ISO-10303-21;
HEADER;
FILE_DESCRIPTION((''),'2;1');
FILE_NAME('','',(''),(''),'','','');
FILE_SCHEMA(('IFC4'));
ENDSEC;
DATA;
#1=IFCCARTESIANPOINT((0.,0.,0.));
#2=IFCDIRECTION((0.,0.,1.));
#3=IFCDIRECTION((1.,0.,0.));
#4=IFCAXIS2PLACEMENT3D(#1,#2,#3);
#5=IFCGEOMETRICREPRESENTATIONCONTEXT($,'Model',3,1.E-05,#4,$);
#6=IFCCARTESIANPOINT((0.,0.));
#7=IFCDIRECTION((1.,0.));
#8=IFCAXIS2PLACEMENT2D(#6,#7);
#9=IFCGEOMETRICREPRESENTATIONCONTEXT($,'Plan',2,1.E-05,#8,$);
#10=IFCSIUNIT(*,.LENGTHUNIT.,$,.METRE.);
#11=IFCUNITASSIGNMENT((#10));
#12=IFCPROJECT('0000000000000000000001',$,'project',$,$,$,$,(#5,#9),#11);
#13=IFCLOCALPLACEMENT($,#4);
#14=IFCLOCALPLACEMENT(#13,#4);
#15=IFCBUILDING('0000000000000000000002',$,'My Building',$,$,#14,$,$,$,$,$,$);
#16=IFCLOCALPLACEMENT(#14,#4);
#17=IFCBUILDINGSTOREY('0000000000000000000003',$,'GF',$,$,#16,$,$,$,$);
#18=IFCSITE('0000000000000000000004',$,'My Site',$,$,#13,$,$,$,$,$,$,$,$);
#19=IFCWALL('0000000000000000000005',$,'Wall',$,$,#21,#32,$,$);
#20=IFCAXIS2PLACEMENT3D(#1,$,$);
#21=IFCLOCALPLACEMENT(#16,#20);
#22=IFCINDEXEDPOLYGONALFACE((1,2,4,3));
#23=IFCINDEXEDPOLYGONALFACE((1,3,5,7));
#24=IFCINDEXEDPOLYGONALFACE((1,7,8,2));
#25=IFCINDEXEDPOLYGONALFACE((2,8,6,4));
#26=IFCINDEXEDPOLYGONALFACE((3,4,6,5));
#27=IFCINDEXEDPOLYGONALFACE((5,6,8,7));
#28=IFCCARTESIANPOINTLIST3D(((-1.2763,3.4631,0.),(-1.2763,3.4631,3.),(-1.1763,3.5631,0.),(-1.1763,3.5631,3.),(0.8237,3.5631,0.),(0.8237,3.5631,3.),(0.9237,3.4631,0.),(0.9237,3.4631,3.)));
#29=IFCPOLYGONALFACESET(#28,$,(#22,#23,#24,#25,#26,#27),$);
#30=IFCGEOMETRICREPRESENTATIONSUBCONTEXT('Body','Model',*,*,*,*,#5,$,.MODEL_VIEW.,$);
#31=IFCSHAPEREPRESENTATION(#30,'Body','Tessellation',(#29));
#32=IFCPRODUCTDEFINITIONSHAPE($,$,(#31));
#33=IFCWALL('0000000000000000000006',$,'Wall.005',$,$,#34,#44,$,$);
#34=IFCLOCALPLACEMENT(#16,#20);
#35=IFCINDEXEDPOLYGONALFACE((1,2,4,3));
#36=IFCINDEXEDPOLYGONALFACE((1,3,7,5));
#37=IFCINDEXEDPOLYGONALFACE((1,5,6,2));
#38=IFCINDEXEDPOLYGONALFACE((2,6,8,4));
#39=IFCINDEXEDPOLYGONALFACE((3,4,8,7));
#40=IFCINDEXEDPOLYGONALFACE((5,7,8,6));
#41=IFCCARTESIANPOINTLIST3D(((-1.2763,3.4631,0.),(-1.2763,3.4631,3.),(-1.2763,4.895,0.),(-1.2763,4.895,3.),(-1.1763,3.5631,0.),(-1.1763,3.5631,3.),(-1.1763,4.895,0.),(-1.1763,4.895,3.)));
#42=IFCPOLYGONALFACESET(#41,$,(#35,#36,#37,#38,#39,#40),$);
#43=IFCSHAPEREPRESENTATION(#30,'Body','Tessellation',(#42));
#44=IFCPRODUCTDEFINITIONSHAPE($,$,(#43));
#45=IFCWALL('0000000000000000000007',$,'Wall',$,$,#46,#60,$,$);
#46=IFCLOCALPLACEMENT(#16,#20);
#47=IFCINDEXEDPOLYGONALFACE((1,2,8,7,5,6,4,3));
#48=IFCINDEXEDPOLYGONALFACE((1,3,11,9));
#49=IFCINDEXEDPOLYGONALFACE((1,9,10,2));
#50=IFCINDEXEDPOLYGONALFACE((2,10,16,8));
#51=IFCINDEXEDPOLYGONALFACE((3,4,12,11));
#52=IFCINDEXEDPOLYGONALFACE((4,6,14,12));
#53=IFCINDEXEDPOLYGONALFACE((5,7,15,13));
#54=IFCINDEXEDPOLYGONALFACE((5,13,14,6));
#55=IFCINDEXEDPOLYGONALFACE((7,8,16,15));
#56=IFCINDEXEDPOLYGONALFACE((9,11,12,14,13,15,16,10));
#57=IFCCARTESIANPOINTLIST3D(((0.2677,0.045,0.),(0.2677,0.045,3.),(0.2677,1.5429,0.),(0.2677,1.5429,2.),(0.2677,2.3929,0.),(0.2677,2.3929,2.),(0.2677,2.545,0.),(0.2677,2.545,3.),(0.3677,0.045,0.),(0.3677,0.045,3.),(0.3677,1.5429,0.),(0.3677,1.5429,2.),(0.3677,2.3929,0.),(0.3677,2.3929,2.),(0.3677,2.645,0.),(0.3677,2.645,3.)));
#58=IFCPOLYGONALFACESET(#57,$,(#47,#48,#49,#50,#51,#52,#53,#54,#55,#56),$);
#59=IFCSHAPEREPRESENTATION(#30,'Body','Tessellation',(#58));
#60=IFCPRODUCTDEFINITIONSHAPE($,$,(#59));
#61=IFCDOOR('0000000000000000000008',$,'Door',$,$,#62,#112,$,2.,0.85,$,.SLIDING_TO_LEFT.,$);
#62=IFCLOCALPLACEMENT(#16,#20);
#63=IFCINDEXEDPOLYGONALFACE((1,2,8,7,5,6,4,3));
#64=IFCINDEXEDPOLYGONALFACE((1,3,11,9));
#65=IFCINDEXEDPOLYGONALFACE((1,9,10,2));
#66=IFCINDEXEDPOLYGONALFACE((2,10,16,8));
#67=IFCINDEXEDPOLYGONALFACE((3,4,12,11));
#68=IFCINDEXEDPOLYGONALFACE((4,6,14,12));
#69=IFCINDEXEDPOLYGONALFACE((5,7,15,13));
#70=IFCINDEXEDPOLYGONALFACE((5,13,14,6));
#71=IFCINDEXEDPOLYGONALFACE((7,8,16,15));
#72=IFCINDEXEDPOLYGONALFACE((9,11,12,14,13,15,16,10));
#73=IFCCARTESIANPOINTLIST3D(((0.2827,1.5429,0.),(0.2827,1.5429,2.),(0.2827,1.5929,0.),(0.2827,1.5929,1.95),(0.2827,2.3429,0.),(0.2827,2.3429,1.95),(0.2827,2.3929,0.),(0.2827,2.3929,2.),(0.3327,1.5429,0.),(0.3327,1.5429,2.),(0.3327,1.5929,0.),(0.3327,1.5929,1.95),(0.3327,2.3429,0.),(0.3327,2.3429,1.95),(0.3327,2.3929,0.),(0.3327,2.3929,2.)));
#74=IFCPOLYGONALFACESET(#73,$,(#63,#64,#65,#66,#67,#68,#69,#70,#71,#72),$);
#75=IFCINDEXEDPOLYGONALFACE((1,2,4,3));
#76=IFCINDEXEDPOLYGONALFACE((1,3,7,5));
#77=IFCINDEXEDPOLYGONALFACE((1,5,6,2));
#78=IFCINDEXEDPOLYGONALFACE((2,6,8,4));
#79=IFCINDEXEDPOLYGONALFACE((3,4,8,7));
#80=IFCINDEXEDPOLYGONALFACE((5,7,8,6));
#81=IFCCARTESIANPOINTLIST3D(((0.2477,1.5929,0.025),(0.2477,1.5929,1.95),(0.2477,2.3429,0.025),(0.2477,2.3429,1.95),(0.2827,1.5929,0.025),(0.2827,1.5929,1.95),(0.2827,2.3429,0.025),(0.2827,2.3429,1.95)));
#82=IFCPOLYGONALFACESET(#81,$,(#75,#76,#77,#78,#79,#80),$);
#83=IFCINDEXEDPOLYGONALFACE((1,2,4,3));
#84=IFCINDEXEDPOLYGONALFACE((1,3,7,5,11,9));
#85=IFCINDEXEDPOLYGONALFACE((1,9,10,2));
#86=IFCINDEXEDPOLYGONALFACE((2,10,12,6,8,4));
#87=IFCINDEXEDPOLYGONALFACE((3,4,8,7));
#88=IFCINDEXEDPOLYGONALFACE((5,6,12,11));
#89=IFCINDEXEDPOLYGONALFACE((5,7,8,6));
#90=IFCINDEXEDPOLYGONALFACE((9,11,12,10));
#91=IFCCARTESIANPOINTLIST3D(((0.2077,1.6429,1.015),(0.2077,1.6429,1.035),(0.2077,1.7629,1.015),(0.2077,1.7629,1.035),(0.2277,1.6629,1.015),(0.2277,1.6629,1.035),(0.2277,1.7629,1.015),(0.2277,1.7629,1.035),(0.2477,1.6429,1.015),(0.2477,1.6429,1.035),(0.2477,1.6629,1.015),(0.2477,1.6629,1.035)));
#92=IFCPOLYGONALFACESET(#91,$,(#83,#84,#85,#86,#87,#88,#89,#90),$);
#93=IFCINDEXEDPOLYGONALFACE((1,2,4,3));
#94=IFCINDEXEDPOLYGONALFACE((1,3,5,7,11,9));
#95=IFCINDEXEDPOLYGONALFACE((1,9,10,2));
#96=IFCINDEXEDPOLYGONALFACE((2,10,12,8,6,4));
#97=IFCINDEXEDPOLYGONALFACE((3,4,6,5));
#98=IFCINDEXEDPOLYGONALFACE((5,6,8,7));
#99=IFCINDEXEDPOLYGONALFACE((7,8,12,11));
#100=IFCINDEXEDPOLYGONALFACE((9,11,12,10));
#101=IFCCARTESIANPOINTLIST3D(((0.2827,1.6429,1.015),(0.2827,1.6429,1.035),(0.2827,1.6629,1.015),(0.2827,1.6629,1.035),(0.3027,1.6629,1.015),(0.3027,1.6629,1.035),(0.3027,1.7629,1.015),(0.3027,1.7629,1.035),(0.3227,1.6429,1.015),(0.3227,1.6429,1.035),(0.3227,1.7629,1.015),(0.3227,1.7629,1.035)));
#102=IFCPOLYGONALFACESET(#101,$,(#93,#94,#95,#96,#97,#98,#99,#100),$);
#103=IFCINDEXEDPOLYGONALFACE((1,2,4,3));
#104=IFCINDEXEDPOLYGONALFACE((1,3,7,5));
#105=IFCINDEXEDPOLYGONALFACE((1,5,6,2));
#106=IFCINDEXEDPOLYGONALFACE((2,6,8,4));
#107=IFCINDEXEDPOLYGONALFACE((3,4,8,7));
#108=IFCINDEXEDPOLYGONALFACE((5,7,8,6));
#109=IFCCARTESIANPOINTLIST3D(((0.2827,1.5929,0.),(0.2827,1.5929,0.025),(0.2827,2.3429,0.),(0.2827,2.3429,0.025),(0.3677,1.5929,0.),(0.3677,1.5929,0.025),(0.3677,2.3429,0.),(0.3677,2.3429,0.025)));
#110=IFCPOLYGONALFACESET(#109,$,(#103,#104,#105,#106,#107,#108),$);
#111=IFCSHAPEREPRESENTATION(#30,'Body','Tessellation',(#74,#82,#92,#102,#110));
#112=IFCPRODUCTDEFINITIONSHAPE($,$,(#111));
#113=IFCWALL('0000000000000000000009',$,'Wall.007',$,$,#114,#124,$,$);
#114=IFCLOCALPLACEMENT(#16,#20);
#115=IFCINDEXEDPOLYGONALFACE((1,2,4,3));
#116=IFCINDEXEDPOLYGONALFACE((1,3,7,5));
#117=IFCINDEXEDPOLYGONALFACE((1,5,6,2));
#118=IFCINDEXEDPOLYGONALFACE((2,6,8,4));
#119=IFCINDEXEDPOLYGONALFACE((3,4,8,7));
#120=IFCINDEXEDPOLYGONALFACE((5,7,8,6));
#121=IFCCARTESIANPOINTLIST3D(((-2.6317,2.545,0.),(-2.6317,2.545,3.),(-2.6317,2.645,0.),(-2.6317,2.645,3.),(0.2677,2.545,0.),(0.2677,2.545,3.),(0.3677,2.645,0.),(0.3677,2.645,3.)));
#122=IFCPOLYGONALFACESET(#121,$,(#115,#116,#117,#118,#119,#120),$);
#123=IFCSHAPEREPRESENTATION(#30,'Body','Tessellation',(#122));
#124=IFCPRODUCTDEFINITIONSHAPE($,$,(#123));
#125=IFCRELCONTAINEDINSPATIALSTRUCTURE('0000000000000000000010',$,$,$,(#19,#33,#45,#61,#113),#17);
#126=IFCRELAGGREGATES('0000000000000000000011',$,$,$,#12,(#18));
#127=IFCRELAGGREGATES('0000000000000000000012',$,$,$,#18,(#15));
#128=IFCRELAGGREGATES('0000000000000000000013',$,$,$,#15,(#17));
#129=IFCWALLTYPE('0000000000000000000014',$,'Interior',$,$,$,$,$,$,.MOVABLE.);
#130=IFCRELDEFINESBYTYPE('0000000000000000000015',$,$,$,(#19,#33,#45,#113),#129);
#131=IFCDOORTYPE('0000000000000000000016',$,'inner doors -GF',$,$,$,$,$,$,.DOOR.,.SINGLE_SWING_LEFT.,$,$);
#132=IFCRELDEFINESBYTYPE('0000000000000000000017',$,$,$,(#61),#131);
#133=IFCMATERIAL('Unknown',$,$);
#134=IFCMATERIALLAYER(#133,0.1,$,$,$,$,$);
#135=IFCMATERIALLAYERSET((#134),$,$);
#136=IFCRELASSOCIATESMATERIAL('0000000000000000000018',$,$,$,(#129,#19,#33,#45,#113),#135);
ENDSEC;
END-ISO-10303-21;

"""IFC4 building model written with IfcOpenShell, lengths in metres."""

from ifc_helpers import new_model, entity, si_unit, frame, origin_with_axes, origin_2d_with_axis, place, context, subcontext, project, spatial, line, indexed_curve, outline, extrude, shape, source, transform, mapped, material, layer, layer_set, layer_usage, type_object, type_shapes, element, fill, save


model = new_model("IFC4")

# Units and contexts
model_context = context("Model", 3, precision=1e-05, world=origin_with_axes())
plan_context = context("Plan", 2, precision=1e-05, world=origin_2d_with_axis())
body_context_1 = subcontext(model_context, "Body", "Model", "MODEL_VIEW")
body_context_2 = subcontext(plan_context, "Body", "Plan", "PLAN_VIEW")
ifc_project = project(units=[si_unit("LENGTHUNIT", "METRE")], contexts=[model_context, plan_context])

# Site, building, storey
site_placement = place(None, origin_with_axes())
site = spatial("IfcSite", under=ifc_project, at=site_placement, Name="My Site")
building_placement = place(site_placement, origin_with_axes())
building = spatial("IfcBuilding", under=site, at=building_placement, Name="My Building")
storey_placement = place(building_placement, origin_with_axes())
storey = spatial("IfcBuildingStorey", under=building, at=storey_placement, Name="GF")

# Shared definitions
ifc_material = material(Name="Unknown")

# Walls
ifc_layer_1 = layer(ifc_material, 0.1)
ifc_layer_set_1 = layer_set([ifc_layer_1])
wall_type_1 = type_object("IfcWallType", Name="Interior", PredefinedType="MOVABLE", material=ifc_layer_set_1)
ifc_layer_usage_1 = layer_usage(ifc_layer_set_1, "AXIS2", "POSITIVE", 0.0)
wall_1_placement = place(storey_placement, frame((0.8237, 3.5631, 0.0), z_axis=(0.0, 0.0, 1.0), x_axis=(-1.0, 0.0, 0.0)))
element("IfcWall", 1, at=wall_1_placement, inside=storey, type_object=wall_type_1, material=ifc_layer_usage_1, Name="Wall", context=body_context_1, shape_type="SweptSolid", body=[
    extrude(outline(indexed_curve([(0.0, 0.0), (-0.1, 0.1), (2.1, 0.1), (2.0, 0.0)], segments=[line(1, 2, 3, 4, 1)])), origin_with_axes(), (0.0, 0.0, 1.0), 3.0),
])
ifc_layer_usage_2 = layer_usage(ifc_layer_set_1, "AXIS2", "POSITIVE", 0.0)
wall_2_placement = place(storey_placement, frame((-1.1763, 3.5631, 0.0), z_axis=(0.0, 0.0, 1.0), x_axis=(0.0, 1.0, 0.0)))
element("IfcWall", 2, at=wall_2_placement, inside=storey, type_object=wall_type_1, material=ifc_layer_usage_2, Name="Wall.005", context=body_context_1, shape_type="SweptSolid", body=[
    extrude(outline(indexed_curve([(0.0, 0.0), (-0.1, 0.1), (1.3318, 0.1), (1.3318, 0.0)], segments=[line(1, 2, 3, 4, 1)])), origin_with_axes(), (0.0, 0.0, 1.0), 3.0),
])

# Wall, opening, door
ifc_layer_usage_3 = layer_usage(ifc_layer_set_1, "AXIS2", "POSITIVE", 0.0)
wall_3_placement = place(storey_placement, frame((0.3677, 0.045, 0.0), z_axis=(0.0, 0.0, 1.0), x_axis=(0.0, 1.0, 0.0)))
wall_3 = element("IfcWall", 3, at=wall_3_placement, inside=storey, type_object=wall_type_1, material=ifc_layer_usage_3, Name="Wall", context=body_context_1, shape_type="SweptSolid", body=[
    extrude(outline(indexed_curve([(0.0, 0.0), (0.0, 0.1), (2.5, 0.1), (2.6, 0.0)], segments=[line(1, 2, 3, 4, 1)])), origin_with_axes(), (0.0, 0.0, 1.0), 3.0),
])
shared_shape_1 = source(origin_with_axes(), body_context_1, "Body", "SweptSolid", [
    extrude(outline(indexed_curve([(0.0, 0.0), (0.85, 0.0), (0.85, 2.0), (0.0, 2.0)], segments=[line(1, 2, 3, 4, 1)])), frame((0.0, -0.6, 0.0), z_axis=(0.0, -1.0, 0.0), x_axis=(1.0, 0.0, 0.0)), (0.0, 0.0, -1.0), 1.2),
])
opening_1_placement = place(wall_3_placement, frame((2.3479, 0.1, 0.0), z_axis=(0.0, 0.0, 1.0), x_axis=(-1.0, 0.0, 0.0)))
opening_1 = element("IfcOpeningElement", 4, at=opening_1_placement, cuts=wall_3, PredefinedType="OPENING", context=body_context_1, shape_type="MappedRepresentation", body=[
    mapped(shared_shape_1, transform((0.0, 0.0, 0.0), x_axis=(1.0, 0.0, 0.0), y_axis=(0.0, 1.0, 0.0), z_axis=(0.0, 0.0, 1.0), scale=1.0)),
])
door_type_1 = type_object("IfcDoorType", Name="inner doors -GF", OperationType="SINGLE_SWING_LEFT", PredefinedType="DOOR")
shared_shape_2 = source(origin_with_axes(), body_context_1, "Body", "SweptSolid", [
    extrude(outline(indexed_curve([(0.0, 0.0), (0.0, 2.0), (0.85, 2.0), (0.85, 0.0), (0.8, 0.0), (0.8, 1.95), (0.05, 1.95), (0.05, 0.0)], segments=[line(1, 2, 3, 4, 5, 6, 7, 8, 1)])), frame((0.0, 0.0, 0.0), z_axis=(0.0, -1.0, 0.0), x_axis=(1.0, 0.0, 0.0)), (0.0, 0.0, -1.0), 0.05),
    extrude(outline(indexed_curve([(0.0, 0.0), (0.75, 0.0), (0.75, 0.035), (0.0, 0.035)], segments=[line(1, 2, 3, 4, 1)])), frame((0.05, -0.035, 0.025), z_axis=(0.0, 0.0, 1.0), x_axis=(1.0, 0.0, 0.0)), (0.0, 0.0, 1.0), 1.925),
    extrude(outline(indexed_curve([(0.0, 0.0), (0.0, -0.04), (-0.12, -0.04), (-0.12, -0.02), (-0.02, -0.02), (-0.02, 0.0)], segments=[line(1, 2, 3, 4, 5, 6, 1)])), frame((0.75, -0.035, 1.015), z_axis=(0.0, 0.0, 1.0), x_axis=(1.0, 0.0, 0.0)), (0.0, 0.0, 1.0), 0.02),
    extrude(outline(indexed_curve([(0.0, 0.0), (0.0, 0.04), (-0.12, 0.04), (-0.12, 0.02), (-0.02, 0.02), (-0.02, 0.0)], segments=[line(1, 2, 3, 4, 5, 6, 1)])), frame((0.75, 0.0, 1.015), z_axis=(0.0, 0.0, 1.0), x_axis=(1.0, 0.0, 0.0)), (0.0, 0.0, 1.0), 0.02),
    extrude(outline(indexed_curve([(0.0, 0.0), (0.75, 0.0), (0.75, 0.085), (0.0, 0.085)], segments=[line(1, 2, 3, 4, 1)])), frame((0.05, 0.0, 0.0), z_axis=(0.0, 0.0, 1.0), x_axis=(1.0, 0.0, 0.0)), (0.0, 0.0, 1.0), 0.025),
])
shared_shape_3 = source(origin_with_axes(), body_context_2, "Body", "Curve2D", [
    entity("IfcIndexedPolyCurve", entity("IfcCartesianPointList2D", [[0.0, 0.0], [0.05, 0.0], [0.05, 0.05], [0.0, 0.05]]), [entity("IfcLineIndex", [1, 2, 3, 4, 1])]),
    entity("IfcIndexedPolyCurve", entity("IfcCartesianPointList2D", [[0.85, 0.0], [0.8, 0.0], [0.8, 0.05], [0.85, 0.05]]), [entity("IfcLineIndex", [1, 2, 3, 4, 1])]),
    entity("IfcIndexedPolyCurve", entity("IfcCartesianPointList2D", [[-0.325, -0.035], [0.425, -0.035], [0.425, 0.0], [-0.325, 0.0]]), [entity("IfcLineIndex", [1, 2, 3, 4, 1])]),
])
type_shapes(door_type_1, [shared_shape_2, shared_shape_3])
door_1_placement = place(opening_1_placement, frame((0.0, 0.015, 0.0), z_axis=(0.0, 0.0, 1.0), x_axis=(1.0, 0.0, 0.0)))
door_1 = element("IfcDoor", 5, at=door_1_placement, inside=storey, type_object=door_type_1, Name="Door", OperationType="SLIDING_TO_LEFT", OverallHeight=2.0, OverallWidth=0.85, shapes=[
    shape(body_context_1, "Body", "MappedRepresentation", [mapped(shared_shape_2, transform((0.0, 0.0, 0.0), x_axis=(1.0, 0.0, 0.0), y_axis=(0.0, 1.0, 0.0), z_axis=(0.0, 0.0, 1.0), scale=1.0))]),
    shape(body_context_2, "Body", "MappedRepresentation", [mapped(shared_shape_3, transform((0.0, 0.0, 0.0), x_axis=(1.0, 0.0, 0.0), y_axis=(0.0, 1.0, 0.0), z_axis=(0.0, 0.0, 1.0), scale=1.0))]),
])
fill(opening_1, door_1)

# Wall
ifc_layer_usage_4 = layer_usage(ifc_layer_set_1, "AXIS2", "POSITIVE", 0.0)
wall_4_placement = place(storey_placement, frame((0.3677, 2.645, 0.0), z_axis=(0.0, 0.0, 1.0), x_axis=(-1.0, 0.0, 0.0)))
element("IfcWall", 6, at=wall_4_placement, inside=storey, type_object=wall_type_1, material=ifc_layer_usage_4, Name="Wall.007", context=body_context_1, shape_type="SweptSolid", body=[
    extrude(outline(indexed_curve([(0.0, 0.0), (0.1, 0.1), (2.9994, 0.1), (2.9994, 0.0)], segments=[line(1, 2, 3, 4, 1)])), origin_with_axes(), (0.0, 0.0, 1.0), 3.0),
])

save(model, "model.ifc")
